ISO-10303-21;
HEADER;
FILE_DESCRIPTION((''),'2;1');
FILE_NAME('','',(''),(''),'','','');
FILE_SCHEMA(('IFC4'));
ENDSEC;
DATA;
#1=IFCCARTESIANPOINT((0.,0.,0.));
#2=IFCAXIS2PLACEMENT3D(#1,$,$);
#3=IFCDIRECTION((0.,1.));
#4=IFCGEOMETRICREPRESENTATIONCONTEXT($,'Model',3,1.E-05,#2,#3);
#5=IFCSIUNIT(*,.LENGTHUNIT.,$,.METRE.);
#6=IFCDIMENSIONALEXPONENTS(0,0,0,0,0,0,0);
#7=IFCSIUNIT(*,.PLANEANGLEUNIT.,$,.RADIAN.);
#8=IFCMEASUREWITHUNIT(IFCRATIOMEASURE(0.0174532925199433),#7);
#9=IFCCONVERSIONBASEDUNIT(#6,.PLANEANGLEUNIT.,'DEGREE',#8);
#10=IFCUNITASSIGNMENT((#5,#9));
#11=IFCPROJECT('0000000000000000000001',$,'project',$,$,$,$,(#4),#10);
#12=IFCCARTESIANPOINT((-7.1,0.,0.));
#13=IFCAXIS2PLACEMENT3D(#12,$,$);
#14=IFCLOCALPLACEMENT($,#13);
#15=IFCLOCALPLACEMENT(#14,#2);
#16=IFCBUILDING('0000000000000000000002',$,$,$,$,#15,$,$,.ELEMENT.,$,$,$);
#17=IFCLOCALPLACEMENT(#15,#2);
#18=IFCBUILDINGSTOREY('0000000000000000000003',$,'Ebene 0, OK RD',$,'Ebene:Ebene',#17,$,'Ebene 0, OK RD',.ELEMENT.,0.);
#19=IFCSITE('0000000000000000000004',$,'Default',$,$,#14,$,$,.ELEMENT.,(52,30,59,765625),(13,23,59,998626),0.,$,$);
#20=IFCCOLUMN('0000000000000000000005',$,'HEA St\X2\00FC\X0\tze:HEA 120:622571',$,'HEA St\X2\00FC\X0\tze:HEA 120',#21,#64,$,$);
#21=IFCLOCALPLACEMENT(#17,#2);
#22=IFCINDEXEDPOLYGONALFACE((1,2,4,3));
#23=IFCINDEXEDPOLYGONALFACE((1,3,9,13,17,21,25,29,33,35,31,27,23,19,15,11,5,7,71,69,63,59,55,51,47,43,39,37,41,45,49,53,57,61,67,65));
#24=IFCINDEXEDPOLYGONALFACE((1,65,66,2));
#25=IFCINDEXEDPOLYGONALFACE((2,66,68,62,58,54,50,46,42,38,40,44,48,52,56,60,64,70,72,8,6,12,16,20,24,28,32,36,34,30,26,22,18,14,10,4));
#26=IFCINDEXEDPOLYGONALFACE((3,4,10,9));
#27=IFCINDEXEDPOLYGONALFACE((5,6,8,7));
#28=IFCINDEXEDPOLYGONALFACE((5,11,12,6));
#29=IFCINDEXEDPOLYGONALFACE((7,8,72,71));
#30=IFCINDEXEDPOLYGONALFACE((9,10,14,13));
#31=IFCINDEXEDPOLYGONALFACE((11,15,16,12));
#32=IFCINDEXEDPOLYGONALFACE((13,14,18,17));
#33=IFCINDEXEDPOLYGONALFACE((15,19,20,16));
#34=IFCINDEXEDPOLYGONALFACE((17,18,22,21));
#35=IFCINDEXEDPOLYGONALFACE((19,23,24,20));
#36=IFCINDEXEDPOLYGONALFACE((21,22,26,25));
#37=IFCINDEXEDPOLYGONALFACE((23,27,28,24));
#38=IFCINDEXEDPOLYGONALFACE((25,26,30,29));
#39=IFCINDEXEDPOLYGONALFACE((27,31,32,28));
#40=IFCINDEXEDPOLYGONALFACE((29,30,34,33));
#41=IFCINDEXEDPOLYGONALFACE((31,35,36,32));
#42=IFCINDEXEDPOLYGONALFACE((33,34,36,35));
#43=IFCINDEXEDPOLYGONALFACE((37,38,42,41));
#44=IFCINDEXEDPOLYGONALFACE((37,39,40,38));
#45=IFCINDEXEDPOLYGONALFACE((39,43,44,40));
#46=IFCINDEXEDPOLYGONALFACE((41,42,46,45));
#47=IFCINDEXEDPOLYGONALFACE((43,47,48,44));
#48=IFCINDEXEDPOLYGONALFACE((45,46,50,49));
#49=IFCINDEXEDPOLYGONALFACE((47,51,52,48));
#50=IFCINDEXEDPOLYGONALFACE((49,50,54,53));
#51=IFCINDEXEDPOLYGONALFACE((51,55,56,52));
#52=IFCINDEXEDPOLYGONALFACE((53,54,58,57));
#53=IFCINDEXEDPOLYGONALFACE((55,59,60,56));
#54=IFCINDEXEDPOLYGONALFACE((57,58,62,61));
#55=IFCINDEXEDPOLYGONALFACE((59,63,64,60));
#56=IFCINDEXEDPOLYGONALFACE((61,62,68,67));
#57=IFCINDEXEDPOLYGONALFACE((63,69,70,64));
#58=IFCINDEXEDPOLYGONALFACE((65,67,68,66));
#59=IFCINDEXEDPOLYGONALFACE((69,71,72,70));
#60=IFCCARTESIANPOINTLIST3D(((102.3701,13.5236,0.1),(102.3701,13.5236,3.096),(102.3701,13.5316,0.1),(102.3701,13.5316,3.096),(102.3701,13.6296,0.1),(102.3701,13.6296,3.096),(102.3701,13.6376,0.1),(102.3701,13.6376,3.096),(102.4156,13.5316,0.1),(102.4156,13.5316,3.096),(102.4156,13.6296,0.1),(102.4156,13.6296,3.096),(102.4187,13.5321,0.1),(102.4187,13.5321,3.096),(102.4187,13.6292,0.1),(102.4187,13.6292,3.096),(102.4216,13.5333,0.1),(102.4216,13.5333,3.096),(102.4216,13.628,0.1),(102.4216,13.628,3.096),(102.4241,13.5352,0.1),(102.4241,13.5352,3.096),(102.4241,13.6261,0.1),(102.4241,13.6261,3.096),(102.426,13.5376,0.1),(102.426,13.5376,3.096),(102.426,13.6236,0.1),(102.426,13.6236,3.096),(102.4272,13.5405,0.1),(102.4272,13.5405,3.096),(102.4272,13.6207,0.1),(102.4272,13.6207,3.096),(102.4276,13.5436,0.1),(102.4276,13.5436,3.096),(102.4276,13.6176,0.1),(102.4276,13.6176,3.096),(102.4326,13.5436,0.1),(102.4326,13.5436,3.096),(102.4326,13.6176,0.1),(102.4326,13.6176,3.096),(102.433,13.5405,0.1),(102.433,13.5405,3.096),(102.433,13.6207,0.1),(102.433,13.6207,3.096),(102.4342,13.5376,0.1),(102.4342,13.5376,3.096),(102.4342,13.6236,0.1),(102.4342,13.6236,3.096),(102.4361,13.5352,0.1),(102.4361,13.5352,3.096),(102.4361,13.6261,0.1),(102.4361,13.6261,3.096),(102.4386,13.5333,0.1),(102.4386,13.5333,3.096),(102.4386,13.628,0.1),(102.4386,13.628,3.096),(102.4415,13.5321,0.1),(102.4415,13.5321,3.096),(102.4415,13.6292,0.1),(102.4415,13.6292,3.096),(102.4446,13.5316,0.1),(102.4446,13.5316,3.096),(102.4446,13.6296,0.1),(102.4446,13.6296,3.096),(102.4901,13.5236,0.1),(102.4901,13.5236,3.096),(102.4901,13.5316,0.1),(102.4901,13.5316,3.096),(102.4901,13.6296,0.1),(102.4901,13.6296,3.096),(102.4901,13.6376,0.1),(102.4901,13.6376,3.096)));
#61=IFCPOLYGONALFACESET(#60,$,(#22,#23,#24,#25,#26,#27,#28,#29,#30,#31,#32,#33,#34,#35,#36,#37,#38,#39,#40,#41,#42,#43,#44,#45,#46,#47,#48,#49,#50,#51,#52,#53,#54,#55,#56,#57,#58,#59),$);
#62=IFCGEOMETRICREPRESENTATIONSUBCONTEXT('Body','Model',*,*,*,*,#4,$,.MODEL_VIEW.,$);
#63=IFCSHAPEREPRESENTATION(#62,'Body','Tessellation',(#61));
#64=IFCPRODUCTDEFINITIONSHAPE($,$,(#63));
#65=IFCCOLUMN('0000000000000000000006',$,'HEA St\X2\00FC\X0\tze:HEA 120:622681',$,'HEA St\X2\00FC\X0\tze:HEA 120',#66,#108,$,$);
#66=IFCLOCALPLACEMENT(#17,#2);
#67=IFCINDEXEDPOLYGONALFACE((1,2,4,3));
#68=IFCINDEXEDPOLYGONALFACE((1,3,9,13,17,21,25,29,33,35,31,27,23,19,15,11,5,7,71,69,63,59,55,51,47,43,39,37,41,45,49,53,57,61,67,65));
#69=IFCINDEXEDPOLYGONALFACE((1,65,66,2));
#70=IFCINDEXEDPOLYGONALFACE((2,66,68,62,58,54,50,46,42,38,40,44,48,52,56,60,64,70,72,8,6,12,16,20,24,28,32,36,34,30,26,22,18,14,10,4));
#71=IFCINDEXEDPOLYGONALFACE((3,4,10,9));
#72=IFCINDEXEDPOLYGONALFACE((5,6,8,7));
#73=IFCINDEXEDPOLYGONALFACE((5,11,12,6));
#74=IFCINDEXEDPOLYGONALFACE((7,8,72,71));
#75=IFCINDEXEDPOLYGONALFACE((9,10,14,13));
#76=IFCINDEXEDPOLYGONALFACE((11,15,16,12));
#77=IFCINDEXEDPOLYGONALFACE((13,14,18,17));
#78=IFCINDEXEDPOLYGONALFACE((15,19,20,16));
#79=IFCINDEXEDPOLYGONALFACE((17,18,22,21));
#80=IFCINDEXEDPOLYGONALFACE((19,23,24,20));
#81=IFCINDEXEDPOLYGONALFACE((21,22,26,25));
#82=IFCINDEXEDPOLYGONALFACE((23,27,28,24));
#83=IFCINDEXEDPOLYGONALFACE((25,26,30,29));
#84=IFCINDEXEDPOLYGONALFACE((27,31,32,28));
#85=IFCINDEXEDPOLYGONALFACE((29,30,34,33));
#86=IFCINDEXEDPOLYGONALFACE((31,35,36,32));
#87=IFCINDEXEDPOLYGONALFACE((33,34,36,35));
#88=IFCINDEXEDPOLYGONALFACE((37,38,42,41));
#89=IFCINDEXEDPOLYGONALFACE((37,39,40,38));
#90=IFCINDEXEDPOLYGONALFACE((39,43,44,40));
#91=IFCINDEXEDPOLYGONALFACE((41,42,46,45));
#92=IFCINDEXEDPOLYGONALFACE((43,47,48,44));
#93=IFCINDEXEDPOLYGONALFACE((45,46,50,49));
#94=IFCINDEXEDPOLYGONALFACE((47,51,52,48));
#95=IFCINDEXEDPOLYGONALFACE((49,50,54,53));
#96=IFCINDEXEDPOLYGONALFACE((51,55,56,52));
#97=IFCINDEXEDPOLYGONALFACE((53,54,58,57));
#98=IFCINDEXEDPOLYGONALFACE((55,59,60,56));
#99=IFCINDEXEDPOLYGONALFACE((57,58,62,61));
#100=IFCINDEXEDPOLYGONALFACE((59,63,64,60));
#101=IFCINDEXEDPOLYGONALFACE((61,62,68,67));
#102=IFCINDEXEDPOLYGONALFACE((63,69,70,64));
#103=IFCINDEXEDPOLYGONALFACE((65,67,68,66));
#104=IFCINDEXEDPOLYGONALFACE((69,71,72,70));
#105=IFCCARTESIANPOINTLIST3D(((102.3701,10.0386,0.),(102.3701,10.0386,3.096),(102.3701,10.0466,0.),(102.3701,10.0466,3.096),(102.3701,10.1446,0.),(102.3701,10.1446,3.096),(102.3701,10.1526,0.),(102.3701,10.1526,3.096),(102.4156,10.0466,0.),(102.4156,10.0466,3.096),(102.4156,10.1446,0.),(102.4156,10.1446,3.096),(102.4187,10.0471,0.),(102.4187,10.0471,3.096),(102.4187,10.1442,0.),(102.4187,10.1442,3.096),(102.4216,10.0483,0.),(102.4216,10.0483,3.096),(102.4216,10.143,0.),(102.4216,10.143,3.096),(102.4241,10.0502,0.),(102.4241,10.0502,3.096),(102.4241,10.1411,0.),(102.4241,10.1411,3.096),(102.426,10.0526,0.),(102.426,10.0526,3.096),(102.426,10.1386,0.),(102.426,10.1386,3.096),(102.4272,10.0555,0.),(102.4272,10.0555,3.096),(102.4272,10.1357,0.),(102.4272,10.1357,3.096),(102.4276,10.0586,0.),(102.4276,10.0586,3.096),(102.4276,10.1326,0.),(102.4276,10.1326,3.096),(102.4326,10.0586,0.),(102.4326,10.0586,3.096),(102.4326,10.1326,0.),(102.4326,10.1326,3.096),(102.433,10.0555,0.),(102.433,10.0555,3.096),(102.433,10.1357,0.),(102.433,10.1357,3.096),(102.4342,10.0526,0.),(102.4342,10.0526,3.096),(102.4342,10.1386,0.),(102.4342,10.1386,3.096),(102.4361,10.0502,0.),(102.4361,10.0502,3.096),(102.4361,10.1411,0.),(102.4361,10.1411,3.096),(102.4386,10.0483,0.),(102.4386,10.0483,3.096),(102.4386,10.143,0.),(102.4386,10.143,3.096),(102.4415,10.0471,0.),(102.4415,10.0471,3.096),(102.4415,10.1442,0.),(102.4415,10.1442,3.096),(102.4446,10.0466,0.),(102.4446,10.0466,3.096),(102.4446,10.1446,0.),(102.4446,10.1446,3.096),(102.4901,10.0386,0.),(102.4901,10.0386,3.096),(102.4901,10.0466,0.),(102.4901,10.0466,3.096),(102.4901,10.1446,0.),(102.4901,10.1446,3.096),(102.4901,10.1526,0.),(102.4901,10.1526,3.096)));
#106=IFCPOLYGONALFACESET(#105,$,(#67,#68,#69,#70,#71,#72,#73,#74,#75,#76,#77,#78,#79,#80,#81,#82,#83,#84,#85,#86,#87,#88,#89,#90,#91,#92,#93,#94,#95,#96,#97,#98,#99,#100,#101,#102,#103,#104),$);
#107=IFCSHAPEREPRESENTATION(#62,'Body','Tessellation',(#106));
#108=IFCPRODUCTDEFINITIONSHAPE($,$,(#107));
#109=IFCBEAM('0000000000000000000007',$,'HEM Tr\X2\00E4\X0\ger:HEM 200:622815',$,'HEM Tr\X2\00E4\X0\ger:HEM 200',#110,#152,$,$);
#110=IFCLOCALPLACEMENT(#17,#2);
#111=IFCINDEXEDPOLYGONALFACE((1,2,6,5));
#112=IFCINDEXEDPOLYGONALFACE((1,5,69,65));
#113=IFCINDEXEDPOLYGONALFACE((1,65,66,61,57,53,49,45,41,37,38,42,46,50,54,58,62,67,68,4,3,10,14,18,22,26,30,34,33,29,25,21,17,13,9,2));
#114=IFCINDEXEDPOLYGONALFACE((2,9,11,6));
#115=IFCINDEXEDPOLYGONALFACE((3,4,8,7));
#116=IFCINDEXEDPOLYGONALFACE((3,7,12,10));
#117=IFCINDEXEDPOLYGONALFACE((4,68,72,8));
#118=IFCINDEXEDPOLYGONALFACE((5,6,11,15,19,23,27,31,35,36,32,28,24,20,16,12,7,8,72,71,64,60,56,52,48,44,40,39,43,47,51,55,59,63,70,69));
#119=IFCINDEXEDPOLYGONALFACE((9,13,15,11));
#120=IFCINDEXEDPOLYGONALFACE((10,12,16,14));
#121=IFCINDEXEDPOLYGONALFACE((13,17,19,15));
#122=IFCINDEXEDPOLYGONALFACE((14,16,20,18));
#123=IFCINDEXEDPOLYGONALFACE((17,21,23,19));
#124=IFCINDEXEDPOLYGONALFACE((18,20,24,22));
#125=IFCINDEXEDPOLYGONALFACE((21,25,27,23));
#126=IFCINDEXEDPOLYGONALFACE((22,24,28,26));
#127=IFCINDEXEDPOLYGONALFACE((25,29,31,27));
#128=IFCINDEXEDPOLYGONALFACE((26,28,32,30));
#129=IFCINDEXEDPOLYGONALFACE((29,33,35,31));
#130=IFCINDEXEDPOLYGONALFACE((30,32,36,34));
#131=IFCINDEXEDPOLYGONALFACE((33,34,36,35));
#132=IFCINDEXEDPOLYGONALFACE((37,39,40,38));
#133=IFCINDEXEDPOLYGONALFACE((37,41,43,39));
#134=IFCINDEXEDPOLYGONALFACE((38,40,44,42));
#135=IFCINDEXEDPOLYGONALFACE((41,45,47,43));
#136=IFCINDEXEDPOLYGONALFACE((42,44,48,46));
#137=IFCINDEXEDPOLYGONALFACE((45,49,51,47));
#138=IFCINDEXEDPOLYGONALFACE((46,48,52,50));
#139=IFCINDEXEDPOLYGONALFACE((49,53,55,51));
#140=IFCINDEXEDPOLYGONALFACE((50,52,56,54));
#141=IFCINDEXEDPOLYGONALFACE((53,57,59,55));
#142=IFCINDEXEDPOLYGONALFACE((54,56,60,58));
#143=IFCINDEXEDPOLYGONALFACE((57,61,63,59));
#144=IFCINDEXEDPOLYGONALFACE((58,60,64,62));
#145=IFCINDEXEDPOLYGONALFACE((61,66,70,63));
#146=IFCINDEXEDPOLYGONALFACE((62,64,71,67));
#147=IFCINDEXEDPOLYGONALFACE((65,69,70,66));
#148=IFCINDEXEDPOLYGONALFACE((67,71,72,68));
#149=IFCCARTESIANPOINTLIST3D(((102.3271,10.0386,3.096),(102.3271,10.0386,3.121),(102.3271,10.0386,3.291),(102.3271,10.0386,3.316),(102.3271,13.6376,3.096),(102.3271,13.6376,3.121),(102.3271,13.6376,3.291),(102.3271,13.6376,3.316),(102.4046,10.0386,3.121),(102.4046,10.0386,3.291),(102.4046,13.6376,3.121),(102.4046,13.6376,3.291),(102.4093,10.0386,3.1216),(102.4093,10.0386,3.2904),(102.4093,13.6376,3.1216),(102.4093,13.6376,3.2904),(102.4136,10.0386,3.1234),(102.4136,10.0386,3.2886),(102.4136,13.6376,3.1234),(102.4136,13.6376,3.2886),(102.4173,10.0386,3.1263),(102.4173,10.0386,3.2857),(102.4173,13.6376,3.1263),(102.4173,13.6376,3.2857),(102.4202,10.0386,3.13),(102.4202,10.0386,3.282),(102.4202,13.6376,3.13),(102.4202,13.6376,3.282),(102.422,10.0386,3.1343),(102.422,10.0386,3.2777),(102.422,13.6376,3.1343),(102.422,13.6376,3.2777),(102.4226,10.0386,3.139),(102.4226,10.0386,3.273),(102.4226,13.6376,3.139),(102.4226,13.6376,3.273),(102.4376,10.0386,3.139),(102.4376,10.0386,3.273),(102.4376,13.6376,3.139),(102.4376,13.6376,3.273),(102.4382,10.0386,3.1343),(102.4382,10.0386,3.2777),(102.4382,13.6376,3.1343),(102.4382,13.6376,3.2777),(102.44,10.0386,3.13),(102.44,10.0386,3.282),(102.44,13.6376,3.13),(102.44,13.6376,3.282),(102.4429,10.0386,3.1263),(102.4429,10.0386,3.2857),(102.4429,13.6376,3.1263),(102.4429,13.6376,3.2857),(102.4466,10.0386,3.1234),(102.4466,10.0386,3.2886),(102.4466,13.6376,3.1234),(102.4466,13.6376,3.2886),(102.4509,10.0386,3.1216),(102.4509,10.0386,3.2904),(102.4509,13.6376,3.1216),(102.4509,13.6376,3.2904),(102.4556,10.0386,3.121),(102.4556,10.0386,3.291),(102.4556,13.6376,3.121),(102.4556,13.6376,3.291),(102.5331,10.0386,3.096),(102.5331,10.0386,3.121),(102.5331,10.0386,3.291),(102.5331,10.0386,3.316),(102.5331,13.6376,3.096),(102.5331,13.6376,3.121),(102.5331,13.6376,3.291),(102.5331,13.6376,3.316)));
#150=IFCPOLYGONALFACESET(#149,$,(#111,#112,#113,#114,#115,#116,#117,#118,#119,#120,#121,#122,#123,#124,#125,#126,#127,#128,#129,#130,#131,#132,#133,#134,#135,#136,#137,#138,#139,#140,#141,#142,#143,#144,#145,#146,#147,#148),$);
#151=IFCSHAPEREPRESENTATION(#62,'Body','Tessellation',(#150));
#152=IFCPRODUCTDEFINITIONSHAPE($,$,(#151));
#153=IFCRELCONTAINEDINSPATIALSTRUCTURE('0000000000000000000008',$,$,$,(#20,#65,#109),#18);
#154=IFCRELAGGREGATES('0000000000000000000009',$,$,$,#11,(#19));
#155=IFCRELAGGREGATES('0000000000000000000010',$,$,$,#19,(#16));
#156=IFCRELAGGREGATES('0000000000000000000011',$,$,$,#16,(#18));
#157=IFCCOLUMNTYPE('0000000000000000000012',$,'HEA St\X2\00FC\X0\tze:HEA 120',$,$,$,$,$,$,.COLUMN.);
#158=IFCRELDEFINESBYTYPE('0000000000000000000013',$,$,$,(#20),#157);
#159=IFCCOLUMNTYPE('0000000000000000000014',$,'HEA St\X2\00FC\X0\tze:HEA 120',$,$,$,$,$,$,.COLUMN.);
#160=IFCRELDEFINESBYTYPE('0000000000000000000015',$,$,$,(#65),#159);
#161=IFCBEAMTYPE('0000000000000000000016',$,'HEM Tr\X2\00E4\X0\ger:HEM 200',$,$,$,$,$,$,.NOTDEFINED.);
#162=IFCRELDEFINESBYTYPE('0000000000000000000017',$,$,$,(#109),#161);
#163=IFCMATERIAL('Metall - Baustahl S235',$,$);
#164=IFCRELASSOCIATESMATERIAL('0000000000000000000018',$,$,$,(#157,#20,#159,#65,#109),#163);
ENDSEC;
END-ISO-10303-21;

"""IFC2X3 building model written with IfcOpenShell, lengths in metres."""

from ifc_helpers import new_model, entity, si_unit, converted_unit, direction, frame, frame_2d, origin, place, context, subcontext, project, spatial, polyline, circle_curve, parameter, trimmed, segment, composite_curve, i_section, outline, extrude, source, transform, mapped, material, type_object, type_shapes, element, save


model = new_model("IFC2X3")

# Units and contexts
model_context = context("Model", 3, precision=1e-05, world=origin(), true_north=direction((0.0, 1.0)))
body_context = subcontext(model_context, "Body", "Model", "MODEL_VIEW")
ifc_project = project(units=[si_unit("LENGTHUNIT", "METRE"), converted_unit("PLANEANGLEUNIT", "DEGREE", entity("IfcRatioMeasure", 0.0174532925199433), si_unit("PLANEANGLEUNIT", "RADIAN"), dimensions=[0, 0, 0, 0, 0, 0, 0])], contexts=[model_context])

# Site, building, storey
site_placement = place(None, frame((-7.1, 0.0, 0.0)))
site = spatial("IfcSite", under=ifc_project, at=site_placement, Name="Default", CompositionType="ELEMENT", RefLatitude=(52, 30, 59, 765625), RefLongitude=(13, 23, 59, 998626), RefElevation=0.0)
building_placement = place(site_placement, origin())
building = spatial("IfcBuilding", under=site, at=building_placement, CompositionType="ELEMENT")
storey_placement = place(building_placement, origin())
storey = spatial("IfcBuildingStorey", under=building, at=storey_placement, Name="Ebene 0, OK RD", ObjectType="Ebene:Ebene", LongName="Ebene 0, OK RD", CompositionType="ELEMENT", Elevation=0.0)

# Columns
ifc_material_1 = material(Name="Metall - Baustahl S235")
column_type_1 = type_object("IfcColumnType", Name="HEA Stütze:HEA 120", PredefinedType="COLUMN", material=ifc_material_1)
shared_shape_1 = source(origin(), body_context, "Body", "SweptSolid", [
    extrude(outline(composite_curve([segment(polyline([(0.049, -0.06), (0.057, -0.06)]), True, "CONTINUOUS"), segment(polyline([(0.057, -0.06), (0.057, 0.06)]), True, "CONTINUOUS"), segment(polyline([(0.057, 0.06), (0.049, 0.06)]), True, "CONTINUOUS"), segment(polyline([(0.049, 0.06), (0.049, 0.0145)]), True, "CONTINUOUS"), segment(trimmed(circle_curve(frame_2d((0.037, 0.0145), x_axis=(1.0, 0.0)), 0.012), [parameter(270.0)], [parameter(0.0)], True, "PARAMETER"), False, "CONTINUOUS"), segment(polyline([(0.037, 0.0025), (-0.037, 0.0025)]), True, "CONTINUOUS"), segment(trimmed(circle_curve(frame_2d((-0.037, 0.0145), x_axis=(0.0, -1.0)), 0.012), [parameter(270.0)], [parameter(0.0)], True, "PARAMETER"), False, "CONTINUOUS"), segment(polyline([(-0.049, 0.0145), (-0.049, 0.06)]), True, "CONTINUOUS"), segment(polyline([(-0.049, 0.06), (-0.057, 0.06)]), True, "CONTINUOUS"), segment(polyline([(-0.057, 0.06), (-0.057, -0.06)]), True, "CONTINUOUS"), segment(polyline([(-0.057, -0.06), (-0.049, -0.06)]), True, "CONTINUOUS"), segment(polyline([(-0.049, -0.06), (-0.049, -0.0145)]), True, "CONTINUOUS"), segment(trimmed(circle_curve(frame_2d((-0.037, -0.0145), x_axis=(-1.0, 0.0)), 0.012), [parameter(270.0)], [parameter(0.0)], True, "PARAMETER"), False, "CONTINUOUS"), segment(polyline([(-0.037, -0.0025), (0.037, -0.0025)]), True, "CONTINUOUS"), segment(trimmed(circle_curve(frame_2d((0.037, -0.0145), x_axis=(0.0, 1.0)), 0.012), [parameter(270.0)], [parameter(0.0)], True, "PARAMETER"), False, "CONTINUOUS"), segment(polyline([(0.049, -0.0145), (0.049, -0.06)]), True, "CONTINUOUS")], self_intersect=False)), frame((0.0, 0.0, 0.1), z_axis=(0.0, 0.0, 1.0), x_axis=(0.0, -1.0, 0.0)), (0.0, 0.0, 1.0), 2.996),
])
type_shapes(column_type_1, [shared_shape_1])
column_1_placement = place(storey_placement, frame((102.4301, 13.5806, 0.0), z_axis=(0.0, 0.0, 1.0), x_axis=(-1.0, 0.0, 0.0)))
element("IfcColumn", 1, at=column_1_placement, inside=storey, type_object=column_type_1, material=ifc_material_1, Name="HEA Stütze:HEA 120:622571", ObjectType="HEA Stütze:HEA 120", context=body_context, shape_type="MappedRepresentation", body=[
    mapped(shared_shape_1, transform((0.0, 0.0, 0.0), scale=1.0)),
])
column_type_2 = type_object("IfcColumnType", Name="HEA Stütze:HEA 120", PredefinedType="COLUMN", material=ifc_material_1)
shared_shape_2 = source(origin(), body_context, "Body", "SweptSolid", [
    extrude(outline(composite_curve([segment(polyline([(0.049, -0.06), (0.057, -0.06)]), True, "CONTINUOUS"), segment(polyline([(0.057, -0.06), (0.057, 0.06)]), True, "CONTINUOUS"), segment(polyline([(0.057, 0.06), (0.049, 0.06)]), True, "CONTINUOUS"), segment(polyline([(0.049, 0.06), (0.049, 0.0145)]), True, "CONTINUOUS"), segment(trimmed(circle_curve(frame_2d((0.037, 0.0145), x_axis=(1.0, 0.0)), 0.012), [parameter(270.0)], [parameter(0.0)], True, "PARAMETER"), False, "CONTINUOUS"), segment(polyline([(0.037, 0.0025), (-0.037, 0.0025)]), True, "CONTINUOUS"), segment(trimmed(circle_curve(frame_2d((-0.037, 0.0145), x_axis=(0.0, -1.0)), 0.012), [parameter(270.0)], [parameter(0.0)], True, "PARAMETER"), False, "CONTINUOUS"), segment(polyline([(-0.049, 0.0145), (-0.049, 0.06)]), True, "CONTINUOUS"), segment(polyline([(-0.049, 0.06), (-0.057, 0.06)]), True, "CONTINUOUS"), segment(polyline([(-0.057, 0.06), (-0.057, -0.06)]), True, "CONTINUOUS"), segment(polyline([(-0.057, -0.06), (-0.049, -0.06)]), True, "CONTINUOUS"), segment(polyline([(-0.049, -0.06), (-0.049, -0.0145)]), True, "CONTINUOUS"), segment(trimmed(circle_curve(frame_2d((-0.037, -0.0145), x_axis=(-1.0, 0.0)), 0.012), [parameter(270.0)], [parameter(0.0)], True, "PARAMETER"), False, "CONTINUOUS"), segment(polyline([(-0.037, -0.0025), (0.037, -0.0025)]), True, "CONTINUOUS"), segment(trimmed(circle_curve(frame_2d((0.037, -0.0145), x_axis=(0.0, 1.0)), 0.012), [parameter(270.0)], [parameter(0.0)], True, "PARAMETER"), False, "CONTINUOUS"), segment(polyline([(0.049, -0.0145), (0.049, -0.06)]), True, "CONTINUOUS")], self_intersect=False)), frame((0.0, 0.0, 0.0), z_axis=(0.0, 0.0, 1.0), x_axis=(0.0, -1.0, 0.0)), (0.0, 0.0, 1.0), 3.096),
])
type_shapes(column_type_2, [shared_shape_2])
column_2_placement = place(storey_placement, frame((102.4301, 10.0956, 0.0), z_axis=(0.0, 0.0, 1.0), x_axis=(-1.0, 0.0, 0.0)))
element("IfcColumn", 2, at=column_2_placement, inside=storey, type_object=column_type_2, material=ifc_material_1, Name="HEA Stütze:HEA 120:622681", ObjectType="HEA Stütze:HEA 120", context=body_context, shape_type="MappedRepresentation", body=[
    mapped(shared_shape_2, transform((0.0, 0.0, 0.0), scale=1.0)),
])

# Beam
beam_type = type_object("IfcBeamType", Name="HEM Träger:HEM 200", PredefinedType="NOTDEFINED")
beam_placement = place(storey_placement, frame((102.4301, 10.1146, 3.096), z_axis=(0.0, 0.0, 1.0), x_axis=(0.0, 1.0, 0.0)))
element("IfcBeam", 3, at=beam_placement, inside=storey, type_object=beam_type, material=ifc_material_1, Name="HEM Träger:HEM 200:622815", ObjectType="HEM Träger:HEM 200", context=body_context, shape_type="SweptSolid", body=[
    extrude(i_section(OverallWidth=0.206, OverallDepth=0.22, WebThickness=0.015, FlangeThickness=0.025, FilletRadius=0.018, at=frame_2d((0.0, 0.0), x_axis=(0.0, 1.0))), frame((-0.076, 0.0, 0.11), z_axis=(1.0, 0.0, 0.0), x_axis=(0.0, 0.0, -1.0)), (0.0, 0.0, 1.0), 3.599),
])

save(model, "model.ifc")
